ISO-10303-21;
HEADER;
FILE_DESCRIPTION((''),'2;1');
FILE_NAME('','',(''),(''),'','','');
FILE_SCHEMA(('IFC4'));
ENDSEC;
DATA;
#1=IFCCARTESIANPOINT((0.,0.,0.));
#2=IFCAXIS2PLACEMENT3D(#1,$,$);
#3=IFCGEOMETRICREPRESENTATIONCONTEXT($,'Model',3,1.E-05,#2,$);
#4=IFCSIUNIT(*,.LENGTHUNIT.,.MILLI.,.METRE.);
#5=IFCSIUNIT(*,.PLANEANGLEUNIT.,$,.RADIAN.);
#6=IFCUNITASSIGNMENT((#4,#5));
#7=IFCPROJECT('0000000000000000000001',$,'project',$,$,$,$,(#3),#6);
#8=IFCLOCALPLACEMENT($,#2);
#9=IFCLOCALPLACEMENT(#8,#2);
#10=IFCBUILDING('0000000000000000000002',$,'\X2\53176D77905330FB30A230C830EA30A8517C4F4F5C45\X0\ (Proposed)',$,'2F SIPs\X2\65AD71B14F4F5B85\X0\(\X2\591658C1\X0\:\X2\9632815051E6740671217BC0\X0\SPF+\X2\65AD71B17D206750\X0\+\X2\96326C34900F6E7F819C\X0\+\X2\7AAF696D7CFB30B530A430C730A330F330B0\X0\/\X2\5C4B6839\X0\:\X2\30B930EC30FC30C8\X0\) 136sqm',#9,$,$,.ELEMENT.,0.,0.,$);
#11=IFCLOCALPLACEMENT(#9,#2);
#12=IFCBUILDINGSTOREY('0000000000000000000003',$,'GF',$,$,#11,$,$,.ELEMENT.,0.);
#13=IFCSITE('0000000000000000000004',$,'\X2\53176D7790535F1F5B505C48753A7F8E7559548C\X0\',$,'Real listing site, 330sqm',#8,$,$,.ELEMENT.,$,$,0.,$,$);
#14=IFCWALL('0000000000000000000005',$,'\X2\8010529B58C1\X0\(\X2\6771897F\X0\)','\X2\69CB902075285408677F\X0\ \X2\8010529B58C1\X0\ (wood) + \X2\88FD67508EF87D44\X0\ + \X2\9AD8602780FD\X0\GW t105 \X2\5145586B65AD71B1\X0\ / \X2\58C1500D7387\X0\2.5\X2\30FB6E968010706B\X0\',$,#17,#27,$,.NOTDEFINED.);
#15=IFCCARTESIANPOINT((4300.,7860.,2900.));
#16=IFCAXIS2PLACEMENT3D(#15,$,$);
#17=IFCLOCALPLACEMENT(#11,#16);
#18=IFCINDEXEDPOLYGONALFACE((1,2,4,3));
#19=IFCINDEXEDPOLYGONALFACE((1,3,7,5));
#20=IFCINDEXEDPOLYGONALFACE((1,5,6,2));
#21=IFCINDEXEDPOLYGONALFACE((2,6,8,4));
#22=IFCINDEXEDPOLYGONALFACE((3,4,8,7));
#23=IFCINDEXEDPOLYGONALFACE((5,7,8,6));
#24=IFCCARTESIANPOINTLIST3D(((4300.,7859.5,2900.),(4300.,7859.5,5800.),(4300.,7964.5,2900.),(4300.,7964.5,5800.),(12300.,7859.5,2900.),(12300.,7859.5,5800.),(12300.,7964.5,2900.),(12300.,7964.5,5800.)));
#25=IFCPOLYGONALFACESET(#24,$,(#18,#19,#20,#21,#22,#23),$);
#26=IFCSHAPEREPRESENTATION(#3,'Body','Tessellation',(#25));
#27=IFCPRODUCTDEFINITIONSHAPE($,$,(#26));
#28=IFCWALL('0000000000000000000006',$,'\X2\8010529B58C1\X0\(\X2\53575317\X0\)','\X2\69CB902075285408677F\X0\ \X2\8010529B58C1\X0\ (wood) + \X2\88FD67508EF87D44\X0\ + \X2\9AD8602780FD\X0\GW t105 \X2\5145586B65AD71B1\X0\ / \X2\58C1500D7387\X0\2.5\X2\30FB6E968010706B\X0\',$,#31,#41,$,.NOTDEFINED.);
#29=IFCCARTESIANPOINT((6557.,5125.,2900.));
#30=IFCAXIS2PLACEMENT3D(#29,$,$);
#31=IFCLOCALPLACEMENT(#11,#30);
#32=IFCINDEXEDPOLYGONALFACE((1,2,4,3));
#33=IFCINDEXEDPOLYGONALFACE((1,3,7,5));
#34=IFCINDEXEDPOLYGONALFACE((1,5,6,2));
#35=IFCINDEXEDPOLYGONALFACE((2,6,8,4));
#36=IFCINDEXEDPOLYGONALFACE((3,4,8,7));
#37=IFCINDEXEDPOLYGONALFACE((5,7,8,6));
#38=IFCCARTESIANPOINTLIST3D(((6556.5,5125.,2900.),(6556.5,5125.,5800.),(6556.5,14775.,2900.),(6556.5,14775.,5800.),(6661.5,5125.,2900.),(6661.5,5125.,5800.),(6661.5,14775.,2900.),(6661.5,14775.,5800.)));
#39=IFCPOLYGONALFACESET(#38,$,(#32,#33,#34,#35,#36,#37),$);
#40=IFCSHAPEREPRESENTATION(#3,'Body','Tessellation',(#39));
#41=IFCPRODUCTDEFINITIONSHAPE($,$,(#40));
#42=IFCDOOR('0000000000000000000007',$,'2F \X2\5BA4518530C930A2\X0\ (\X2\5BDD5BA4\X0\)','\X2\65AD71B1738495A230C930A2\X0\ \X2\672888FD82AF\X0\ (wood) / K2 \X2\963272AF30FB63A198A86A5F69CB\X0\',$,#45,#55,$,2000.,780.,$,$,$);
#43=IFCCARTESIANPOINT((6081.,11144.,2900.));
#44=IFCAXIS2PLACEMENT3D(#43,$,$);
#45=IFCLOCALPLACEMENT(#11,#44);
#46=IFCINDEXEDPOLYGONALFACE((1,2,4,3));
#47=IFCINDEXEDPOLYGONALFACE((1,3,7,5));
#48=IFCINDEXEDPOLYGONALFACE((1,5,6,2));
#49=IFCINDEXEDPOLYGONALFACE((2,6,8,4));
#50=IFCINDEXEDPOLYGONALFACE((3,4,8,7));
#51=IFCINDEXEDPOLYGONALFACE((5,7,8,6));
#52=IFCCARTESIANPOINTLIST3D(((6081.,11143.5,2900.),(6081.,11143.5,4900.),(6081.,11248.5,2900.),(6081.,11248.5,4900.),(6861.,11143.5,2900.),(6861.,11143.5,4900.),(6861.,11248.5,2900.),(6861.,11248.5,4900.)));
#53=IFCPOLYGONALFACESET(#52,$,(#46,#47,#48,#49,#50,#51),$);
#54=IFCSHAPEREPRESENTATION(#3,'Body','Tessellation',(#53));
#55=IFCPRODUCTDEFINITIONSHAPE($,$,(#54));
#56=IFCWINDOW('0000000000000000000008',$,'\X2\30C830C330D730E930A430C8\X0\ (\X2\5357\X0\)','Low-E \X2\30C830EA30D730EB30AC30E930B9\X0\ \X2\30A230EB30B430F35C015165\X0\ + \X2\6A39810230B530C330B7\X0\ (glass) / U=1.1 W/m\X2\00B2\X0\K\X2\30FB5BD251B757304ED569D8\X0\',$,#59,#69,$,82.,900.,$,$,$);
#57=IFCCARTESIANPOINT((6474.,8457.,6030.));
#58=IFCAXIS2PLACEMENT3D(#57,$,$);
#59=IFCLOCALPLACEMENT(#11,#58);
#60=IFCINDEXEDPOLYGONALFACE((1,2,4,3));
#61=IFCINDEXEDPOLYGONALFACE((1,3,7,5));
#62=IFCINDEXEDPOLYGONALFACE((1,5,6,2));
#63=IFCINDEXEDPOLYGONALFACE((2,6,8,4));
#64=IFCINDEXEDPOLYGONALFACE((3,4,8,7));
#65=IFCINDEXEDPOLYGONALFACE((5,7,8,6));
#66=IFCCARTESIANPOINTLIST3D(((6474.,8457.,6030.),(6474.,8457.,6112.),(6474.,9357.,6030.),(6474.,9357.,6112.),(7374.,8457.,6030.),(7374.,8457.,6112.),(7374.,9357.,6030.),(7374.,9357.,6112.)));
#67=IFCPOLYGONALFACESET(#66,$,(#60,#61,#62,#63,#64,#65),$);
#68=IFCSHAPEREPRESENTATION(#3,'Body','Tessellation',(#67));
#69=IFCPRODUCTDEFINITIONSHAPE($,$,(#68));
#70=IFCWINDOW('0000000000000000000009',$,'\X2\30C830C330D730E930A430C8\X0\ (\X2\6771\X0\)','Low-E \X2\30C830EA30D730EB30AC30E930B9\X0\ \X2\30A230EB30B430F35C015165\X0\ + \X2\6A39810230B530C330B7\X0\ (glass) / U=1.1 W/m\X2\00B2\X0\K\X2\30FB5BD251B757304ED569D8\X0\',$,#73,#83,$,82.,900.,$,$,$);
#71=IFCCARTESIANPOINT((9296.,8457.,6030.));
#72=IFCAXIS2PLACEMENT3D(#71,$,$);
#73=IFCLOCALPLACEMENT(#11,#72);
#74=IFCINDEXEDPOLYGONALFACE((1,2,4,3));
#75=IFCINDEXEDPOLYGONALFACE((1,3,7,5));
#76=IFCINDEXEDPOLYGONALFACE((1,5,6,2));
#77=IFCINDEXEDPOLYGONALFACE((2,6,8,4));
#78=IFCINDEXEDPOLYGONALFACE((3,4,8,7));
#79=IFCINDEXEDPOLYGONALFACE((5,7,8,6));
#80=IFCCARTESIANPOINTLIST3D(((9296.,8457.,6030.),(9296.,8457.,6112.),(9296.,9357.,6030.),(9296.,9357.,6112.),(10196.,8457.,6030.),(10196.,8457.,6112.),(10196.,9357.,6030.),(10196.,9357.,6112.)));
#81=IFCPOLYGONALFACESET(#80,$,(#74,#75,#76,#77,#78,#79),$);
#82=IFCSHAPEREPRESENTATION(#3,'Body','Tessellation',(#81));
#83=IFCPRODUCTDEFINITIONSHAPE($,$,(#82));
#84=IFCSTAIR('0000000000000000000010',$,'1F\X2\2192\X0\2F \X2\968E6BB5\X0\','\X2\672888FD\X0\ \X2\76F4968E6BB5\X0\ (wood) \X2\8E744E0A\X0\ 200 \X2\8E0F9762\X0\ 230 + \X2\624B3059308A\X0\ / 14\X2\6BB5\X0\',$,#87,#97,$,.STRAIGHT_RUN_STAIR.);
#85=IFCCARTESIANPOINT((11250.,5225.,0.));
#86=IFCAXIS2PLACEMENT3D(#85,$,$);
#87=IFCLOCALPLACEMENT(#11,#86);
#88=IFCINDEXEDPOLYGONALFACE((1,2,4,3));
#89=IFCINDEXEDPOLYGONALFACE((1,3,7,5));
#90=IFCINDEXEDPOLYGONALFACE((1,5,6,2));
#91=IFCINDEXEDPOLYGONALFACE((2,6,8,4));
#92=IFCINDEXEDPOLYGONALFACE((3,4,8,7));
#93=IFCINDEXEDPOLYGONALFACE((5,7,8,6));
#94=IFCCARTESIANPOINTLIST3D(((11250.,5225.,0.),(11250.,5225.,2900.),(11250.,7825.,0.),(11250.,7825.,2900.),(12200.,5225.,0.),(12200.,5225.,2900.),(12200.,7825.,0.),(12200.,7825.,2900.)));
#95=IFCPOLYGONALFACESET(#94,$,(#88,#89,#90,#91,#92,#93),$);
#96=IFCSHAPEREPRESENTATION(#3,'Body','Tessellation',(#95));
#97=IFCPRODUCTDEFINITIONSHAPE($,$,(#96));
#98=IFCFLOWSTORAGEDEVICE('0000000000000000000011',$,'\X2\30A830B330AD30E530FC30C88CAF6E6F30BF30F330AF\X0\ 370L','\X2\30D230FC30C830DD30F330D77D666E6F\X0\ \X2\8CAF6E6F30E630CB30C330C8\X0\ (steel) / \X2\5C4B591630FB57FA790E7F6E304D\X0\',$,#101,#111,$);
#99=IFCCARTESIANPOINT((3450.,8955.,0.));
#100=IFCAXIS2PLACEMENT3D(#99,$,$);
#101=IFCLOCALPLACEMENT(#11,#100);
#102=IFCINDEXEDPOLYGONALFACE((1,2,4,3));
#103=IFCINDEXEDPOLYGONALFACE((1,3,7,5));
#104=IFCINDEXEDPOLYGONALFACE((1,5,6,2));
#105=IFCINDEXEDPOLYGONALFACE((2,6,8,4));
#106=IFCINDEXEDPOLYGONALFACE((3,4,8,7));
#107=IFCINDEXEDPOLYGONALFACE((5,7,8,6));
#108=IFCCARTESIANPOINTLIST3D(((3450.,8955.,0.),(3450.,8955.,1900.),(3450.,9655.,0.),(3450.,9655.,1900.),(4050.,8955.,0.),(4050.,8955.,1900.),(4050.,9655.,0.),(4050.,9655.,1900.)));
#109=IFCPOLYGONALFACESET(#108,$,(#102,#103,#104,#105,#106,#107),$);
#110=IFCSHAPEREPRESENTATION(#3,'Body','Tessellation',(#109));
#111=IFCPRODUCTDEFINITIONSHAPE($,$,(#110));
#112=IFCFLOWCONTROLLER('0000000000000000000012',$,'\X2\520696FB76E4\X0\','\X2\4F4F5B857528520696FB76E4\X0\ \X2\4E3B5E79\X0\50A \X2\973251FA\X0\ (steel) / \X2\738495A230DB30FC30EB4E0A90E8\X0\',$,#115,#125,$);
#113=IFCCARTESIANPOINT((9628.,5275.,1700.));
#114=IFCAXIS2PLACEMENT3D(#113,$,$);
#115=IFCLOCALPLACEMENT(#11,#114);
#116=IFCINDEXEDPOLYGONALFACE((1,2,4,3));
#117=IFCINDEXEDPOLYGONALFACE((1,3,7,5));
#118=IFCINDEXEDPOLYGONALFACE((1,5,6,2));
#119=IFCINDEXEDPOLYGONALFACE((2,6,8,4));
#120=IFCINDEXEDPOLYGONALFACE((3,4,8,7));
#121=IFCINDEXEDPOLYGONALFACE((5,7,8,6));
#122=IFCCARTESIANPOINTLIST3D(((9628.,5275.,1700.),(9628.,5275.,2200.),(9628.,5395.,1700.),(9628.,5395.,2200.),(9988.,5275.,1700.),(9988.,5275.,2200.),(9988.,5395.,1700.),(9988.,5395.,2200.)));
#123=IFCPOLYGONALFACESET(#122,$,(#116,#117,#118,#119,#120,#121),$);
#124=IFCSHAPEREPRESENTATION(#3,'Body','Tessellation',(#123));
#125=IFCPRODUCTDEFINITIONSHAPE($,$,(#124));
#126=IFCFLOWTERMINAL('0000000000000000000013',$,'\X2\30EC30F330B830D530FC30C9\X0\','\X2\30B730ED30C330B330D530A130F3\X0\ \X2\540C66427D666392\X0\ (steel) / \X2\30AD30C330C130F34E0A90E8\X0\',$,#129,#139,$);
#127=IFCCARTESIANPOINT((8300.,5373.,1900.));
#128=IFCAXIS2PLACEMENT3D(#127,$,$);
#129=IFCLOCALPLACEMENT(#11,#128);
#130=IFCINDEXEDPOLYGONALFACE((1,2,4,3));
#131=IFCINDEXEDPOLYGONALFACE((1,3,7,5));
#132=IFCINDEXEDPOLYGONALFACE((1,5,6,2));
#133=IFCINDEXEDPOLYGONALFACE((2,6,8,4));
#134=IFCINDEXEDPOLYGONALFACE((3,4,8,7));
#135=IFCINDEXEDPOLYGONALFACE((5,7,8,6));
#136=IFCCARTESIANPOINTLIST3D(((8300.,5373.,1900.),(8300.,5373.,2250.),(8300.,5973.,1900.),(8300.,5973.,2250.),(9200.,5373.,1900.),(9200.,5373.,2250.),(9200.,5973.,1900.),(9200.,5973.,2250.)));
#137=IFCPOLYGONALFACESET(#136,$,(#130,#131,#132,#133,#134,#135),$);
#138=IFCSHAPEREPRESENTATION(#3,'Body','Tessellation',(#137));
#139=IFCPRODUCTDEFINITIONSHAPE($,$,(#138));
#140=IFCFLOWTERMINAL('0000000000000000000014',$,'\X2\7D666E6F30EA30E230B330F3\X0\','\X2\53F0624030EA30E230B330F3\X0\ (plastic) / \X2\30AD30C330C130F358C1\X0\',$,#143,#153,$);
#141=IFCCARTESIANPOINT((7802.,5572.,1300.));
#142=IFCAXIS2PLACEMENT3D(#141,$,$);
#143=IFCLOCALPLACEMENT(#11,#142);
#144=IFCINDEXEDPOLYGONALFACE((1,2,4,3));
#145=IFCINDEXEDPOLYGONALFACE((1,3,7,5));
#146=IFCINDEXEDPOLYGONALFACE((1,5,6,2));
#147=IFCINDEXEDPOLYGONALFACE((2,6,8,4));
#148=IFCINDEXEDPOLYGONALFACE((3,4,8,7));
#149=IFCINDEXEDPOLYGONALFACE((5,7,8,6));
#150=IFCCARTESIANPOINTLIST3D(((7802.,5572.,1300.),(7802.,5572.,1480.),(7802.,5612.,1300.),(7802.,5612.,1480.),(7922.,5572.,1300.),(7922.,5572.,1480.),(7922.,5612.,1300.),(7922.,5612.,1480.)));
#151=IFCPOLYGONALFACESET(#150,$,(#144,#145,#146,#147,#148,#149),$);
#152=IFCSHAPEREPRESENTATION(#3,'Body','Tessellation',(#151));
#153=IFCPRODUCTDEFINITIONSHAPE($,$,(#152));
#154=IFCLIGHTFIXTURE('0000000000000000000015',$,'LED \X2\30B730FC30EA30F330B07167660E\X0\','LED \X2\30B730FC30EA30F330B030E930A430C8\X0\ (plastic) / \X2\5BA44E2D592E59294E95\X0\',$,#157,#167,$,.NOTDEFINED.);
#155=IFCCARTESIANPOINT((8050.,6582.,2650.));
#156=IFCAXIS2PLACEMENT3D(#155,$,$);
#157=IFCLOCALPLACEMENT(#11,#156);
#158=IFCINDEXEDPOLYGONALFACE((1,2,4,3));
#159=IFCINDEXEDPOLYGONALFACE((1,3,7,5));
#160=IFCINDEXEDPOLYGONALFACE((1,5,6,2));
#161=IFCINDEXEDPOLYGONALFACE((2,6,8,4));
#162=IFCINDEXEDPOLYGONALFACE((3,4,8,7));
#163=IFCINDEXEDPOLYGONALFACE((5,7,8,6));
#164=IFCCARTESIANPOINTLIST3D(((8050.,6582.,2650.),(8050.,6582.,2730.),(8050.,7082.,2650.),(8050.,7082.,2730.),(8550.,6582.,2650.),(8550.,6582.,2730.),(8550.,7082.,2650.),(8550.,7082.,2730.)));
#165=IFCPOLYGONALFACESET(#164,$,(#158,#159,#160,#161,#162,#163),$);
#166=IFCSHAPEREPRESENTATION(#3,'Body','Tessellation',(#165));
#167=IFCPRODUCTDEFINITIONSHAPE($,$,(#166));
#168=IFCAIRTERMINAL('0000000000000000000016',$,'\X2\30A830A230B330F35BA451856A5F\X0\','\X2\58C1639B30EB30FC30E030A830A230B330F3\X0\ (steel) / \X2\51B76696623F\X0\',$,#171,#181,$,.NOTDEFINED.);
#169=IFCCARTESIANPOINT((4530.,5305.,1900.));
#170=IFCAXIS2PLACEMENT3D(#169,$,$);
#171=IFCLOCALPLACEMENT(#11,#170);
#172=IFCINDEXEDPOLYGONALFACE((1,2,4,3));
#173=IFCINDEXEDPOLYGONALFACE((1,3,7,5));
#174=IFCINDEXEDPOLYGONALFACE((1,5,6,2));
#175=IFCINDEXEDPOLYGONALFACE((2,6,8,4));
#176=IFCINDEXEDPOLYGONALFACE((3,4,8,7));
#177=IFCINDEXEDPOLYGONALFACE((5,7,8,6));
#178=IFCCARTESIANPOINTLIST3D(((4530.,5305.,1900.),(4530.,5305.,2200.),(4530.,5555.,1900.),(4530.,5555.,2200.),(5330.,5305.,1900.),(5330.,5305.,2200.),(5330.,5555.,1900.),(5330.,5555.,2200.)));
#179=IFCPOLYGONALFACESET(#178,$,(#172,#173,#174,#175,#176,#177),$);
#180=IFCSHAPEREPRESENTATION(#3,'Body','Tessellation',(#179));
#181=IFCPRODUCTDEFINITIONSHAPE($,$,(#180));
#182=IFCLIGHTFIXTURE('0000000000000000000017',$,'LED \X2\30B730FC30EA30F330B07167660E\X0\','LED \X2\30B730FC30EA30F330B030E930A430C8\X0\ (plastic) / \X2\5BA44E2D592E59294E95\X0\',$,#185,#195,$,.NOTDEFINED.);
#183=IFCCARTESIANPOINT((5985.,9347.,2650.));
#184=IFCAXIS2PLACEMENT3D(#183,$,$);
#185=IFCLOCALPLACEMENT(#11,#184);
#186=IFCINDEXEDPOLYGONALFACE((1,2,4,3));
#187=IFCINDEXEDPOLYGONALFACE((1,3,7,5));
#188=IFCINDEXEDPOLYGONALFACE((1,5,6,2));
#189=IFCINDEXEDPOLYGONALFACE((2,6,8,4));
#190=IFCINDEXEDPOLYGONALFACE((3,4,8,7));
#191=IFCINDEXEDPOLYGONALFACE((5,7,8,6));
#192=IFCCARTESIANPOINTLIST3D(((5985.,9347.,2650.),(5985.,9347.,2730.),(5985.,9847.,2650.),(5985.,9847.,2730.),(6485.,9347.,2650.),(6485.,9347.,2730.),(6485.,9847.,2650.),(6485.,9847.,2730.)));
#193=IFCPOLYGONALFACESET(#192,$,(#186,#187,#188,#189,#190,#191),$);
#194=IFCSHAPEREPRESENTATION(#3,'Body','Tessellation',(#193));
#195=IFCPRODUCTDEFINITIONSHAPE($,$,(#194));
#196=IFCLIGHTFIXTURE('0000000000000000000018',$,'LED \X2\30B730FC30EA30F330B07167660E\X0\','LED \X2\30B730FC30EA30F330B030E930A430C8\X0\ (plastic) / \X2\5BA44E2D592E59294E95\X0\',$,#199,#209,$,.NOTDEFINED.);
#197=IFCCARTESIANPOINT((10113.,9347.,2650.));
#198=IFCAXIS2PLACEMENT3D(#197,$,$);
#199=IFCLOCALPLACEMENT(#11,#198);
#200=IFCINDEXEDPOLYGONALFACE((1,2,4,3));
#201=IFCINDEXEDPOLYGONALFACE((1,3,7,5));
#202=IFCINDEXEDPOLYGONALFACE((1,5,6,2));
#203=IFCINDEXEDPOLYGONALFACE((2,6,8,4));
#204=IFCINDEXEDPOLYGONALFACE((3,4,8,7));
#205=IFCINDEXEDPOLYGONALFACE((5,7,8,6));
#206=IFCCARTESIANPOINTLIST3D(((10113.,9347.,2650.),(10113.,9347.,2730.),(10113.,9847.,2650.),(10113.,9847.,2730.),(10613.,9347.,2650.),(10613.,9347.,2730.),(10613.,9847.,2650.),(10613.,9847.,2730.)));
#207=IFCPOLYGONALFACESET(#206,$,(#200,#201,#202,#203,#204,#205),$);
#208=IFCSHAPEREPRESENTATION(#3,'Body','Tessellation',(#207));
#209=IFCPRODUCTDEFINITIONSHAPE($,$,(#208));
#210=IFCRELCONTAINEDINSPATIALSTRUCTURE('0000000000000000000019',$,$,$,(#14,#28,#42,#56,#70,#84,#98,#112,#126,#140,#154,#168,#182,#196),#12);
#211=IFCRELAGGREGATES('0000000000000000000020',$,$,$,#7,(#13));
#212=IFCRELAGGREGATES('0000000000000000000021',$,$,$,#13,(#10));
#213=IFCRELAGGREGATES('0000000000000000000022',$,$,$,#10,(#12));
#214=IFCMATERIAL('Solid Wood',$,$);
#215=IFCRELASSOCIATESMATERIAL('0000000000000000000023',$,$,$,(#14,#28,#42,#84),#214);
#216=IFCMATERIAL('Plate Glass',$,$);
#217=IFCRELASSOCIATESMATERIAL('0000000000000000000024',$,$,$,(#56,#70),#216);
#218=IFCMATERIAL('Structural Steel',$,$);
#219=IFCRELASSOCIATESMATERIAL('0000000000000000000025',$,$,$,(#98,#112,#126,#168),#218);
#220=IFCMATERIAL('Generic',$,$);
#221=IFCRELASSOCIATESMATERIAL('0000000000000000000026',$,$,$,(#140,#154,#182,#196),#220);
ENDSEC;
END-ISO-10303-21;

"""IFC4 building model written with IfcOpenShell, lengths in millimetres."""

from ifc_helpers import new_model, si_unit, frame, frame_2d, origin, place, context, project, spatial, rectangle, extrude, material, element, fill, save


model = new_model("IFC4")

# Units and contexts
model_context = context("Model", 3, precision=1e-05, world=origin())
ifc_project = project(units=[si_unit("LENGTHUNIT", "METRE", prefix="MILLI"), si_unit("PLANEANGLEUNIT", "RADIAN")], contexts=[model_context])

# Site, building, storey
site_placement = place(None, origin())
site = spatial("IfcSite", under=ifc_project, at=site_placement, Name="北海道弟子屈町美留和", ObjectType="Real listing site, 330sqm", CompositionType="ELEMENT", RefElevation=0.0)
building_placement = place(site_placement, origin())
building = spatial("IfcBuilding", under=site, at=building_placement, Name="北海道・アトリエ兼住居 (Proposed)", ObjectType="2F SIPs断熱住宅(外壁:防腐処理無節SPF+断熱素材+防水透湿膜+窯業系サイディング/屋根:スレート) 136sqm", CompositionType="ELEMENT", ElevationOfRefHeight=0.0, ElevationOfTerrain=0.0)
storey_placement = place(building_placement, origin())
storey = spatial("IfcBuildingStorey", under=building, at=storey_placement, Name="GF", CompositionType="ELEMENT", Elevation=0.0)

# Shared definitions
ifc_material_1 = material(Name="Solid Wood")

# Wall
wall_1_placement = place(storey_placement, frame((4300.0, 7860.0, 2900.0)))
element("IfcWall", 1, at=wall_1_placement, inside=storey, material=ifc_material_1, Name="耐力壁(東西)", Description="構造用合板 耐力壁 (wood) + 製材軸組 + 高性能GW t105 充填断熱 / 壁倍率2.5・準耐火", PredefinedType="NOTDEFINED", context=model_context, shape_type="SweptSolid", body=[
    extrude(rectangle(XDim=8000.0, YDim=105.0, at=frame_2d((4000.0, 52.0))), frame((4300.0, 7860.0, 2900.0)), (0.0, 0.0, 1.0), 2900.0),
])

# Wall, opening, door
wall_2_placement = place(storey_placement, frame((6557.0, 5125.0, 2900.0)))
wall_2 = element("IfcWall", 2, at=wall_2_placement, inside=storey, material=ifc_material_1, Name="耐力壁(南北)", Description="構造用合板 耐力壁 (wood) + 製材軸組 + 高性能GW t105 充填断熱 / 壁倍率2.5・準耐火", PredefinedType="NOTDEFINED", context=model_context, shape_type="SweptSolid", body=[
    extrude(rectangle(XDim=105.0, YDim=9650.0, at=frame_2d((52.0, 4825.0))), frame((6557.0, 5125.0, 2900.0)), (0.0, 0.0, 1.0), 2900.0),
])
opening_placement = place(storey_placement, frame((6081.0, 11144.0, 2900.0)))
opening = element("IfcOpeningElement", 3, at=opening_placement, cuts=wall_2, PredefinedType="NOTDEFINED", context=model_context, shape_type="SweptSolid", body=[
    extrude(rectangle(XDim=780.0, YDim=105.0, at=frame_2d((390.0, 52.0))), frame((6081.0, 11144.0, 2900.0)), (0.0, 0.0, 1.0), 2000.0),
])
door_placement = place(storey_placement, frame((6081.0, 11144.0, 2900.0)))
door = element("IfcDoor", 4, at=door_placement, inside=storey, material=ifc_material_1, Name="2F 室内ドア (寝室)", Description="断熱玄関ドア 木製芯 (wood) / K2 防犯・採風機構", OverallHeight=2000.0, OverallWidth=780.0, context=model_context, shape_type="SweptSolid", body=[
    extrude(rectangle(XDim=780.0, YDim=105.0, at=frame_2d((390.0, 52.0))), frame((6081.0, 11144.0, 2900.0)), (0.0, 0.0, 1.0), 2000.0),
])
fill(opening, door)

# Windows
ifc_material_2 = material(Name="Plate Glass")
window_1_placement = place(storey_placement, frame((6474.0, 8457.0, 6030.0)))
element("IfcWindow", 5, at=window_1_placement, inside=storey, material=ifc_material_2, Name="トップライト (南)", Description="Low-E トリプルガラス アルゴン封入 + 樹脂サッシ (glass) / U=1.1 W/m²K・寒冷地仕様", OverallHeight=82.0, OverallWidth=900.0, context=model_context, shape_type="SweptSolid", body=[
    extrude(rectangle(XDim=900.0, YDim=900.0, at=frame_2d((450.0, 450.0))), frame((6474.0, 8457.0, 6030.0)), (0.0, 0.0, 1.0), 82.0),
])
window_2_placement = place(storey_placement, frame((9296.0, 8457.0, 6030.0)))
element("IfcWindow", 6, at=window_2_placement, inside=storey, material=ifc_material_2, Name="トップライト (東)", Description="Low-E トリプルガラス アルゴン封入 + 樹脂サッシ (glass) / U=1.1 W/m²K・寒冷地仕様", OverallHeight=82.0, OverallWidth=900.0, context=model_context, shape_type="SweptSolid", body=[
    extrude(rectangle(XDim=900.0, YDim=900.0, at=frame_2d((450.0, 450.0))), frame((9296.0, 8457.0, 6030.0)), (0.0, 0.0, 1.0), 82.0),
])

# Stair
stair_placement = place(storey_placement, frame((11250.0, 5225.0, 0.0)))
element("IfcStair", 7, at=stair_placement, inside=storey, material=ifc_material_1, Name="1F→2F 階段", Description="木製 直階段 (wood) 蹴上 200 踏面 230 + 手すり / 14段", PredefinedType="STRAIGHT_RUN_STAIR", context=model_context, shape_type="SweptSolid", body=[
    extrude(rectangle(XDim=950.0, YDim=2600.0, at=frame_2d((475.0, 1300.0))), frame((11250.0, 5225.0, 0.0)), (0.0, 0.0, 1.0), 2900.0),
])

# Flow storage device
ifc_material_3 = material(Name="Structural Steel")
flow_storage_device_placement = place(storey_placement, frame((3450.0, 8955.0, 0.0)))
element("IfcFlowStorageDevice", 8, at=flow_storage_device_placement, inside=storey, material=ifc_material_3, Name="エコキュート貯湯タンク 370L", Description="ヒートポンプ給湯 貯湯ユニット (steel) / 屋外・基礎置き", context=model_context, shape_type="SweptSolid", body=[
    extrude(rectangle(XDim=600.0, YDim=700.0, at=frame_2d((300.0, 350.0))), frame((3450.0, 8955.0, 0.0)), (0.0, 0.0, 1.0), 1900.0),
])

# Flow controller
flow_controller_placement = place(storey_placement, frame((9628.0, 5275.0, 1700.0)))
element("IfcFlowController", 9, at=flow_controller_placement, inside=storey, material=ifc_material_3, Name="分電盤", Description="住宅用分電盤 主幹50A 露出 (steel) / 玄関ホール上部", context=model_context, shape_type="SweptSolid", body=[
    extrude(rectangle(XDim=360.0, YDim=120.0, at=frame_2d((180.0, 60.0))), frame((9628.0, 5275.0, 1700.0)), (0.0, 0.0, 1.0), 500.0),
])

# Flow terminals
flow_terminal_1_placement = place(storey_placement, frame((8300.0, 5373.0, 1900.0)))
element("IfcFlowTerminal", 10, at=flow_terminal_1_placement, inside=storey, material=ifc_material_3, Name="レンジフード", Description="シロッコファン 同時給排 (steel) / キッチン上部", context=model_context, shape_type="SweptSolid", body=[
    extrude(rectangle(XDim=900.0, YDim=600.0, at=frame_2d((450.0, 300.0))), frame((8300.0, 5373.0, 1900.0)), (0.0, 0.0, 1.0), 350.0),
])
ifc_material_4 = material(Name="Generic")
flow_terminal_2_placement = place(storey_placement, frame((7802.0, 5572.0, 1300.0)))
element("IfcFlowTerminal", 11, at=flow_terminal_2_placement, inside=storey, material=ifc_material_4, Name="給湯リモコン", Description="台所リモコン (plastic) / キッチン壁", context=model_context, shape_type="SweptSolid", body=[
    extrude(rectangle(XDim=120.0, YDim=40.0, at=frame_2d((60.0, 20.0))), frame((7802.0, 5572.0, 1300.0)), (0.0, 0.0, 1.0), 180.0),
])

# Light fixture
light_fixture_1_placement = place(storey_placement, frame((8050.0, 6582.0, 2650.0)))
element("IfcLightFixture", 12, at=light_fixture_1_placement, inside=storey, material=ifc_material_4, Name="LED シーリング照明", Description="LED シーリングライト (plastic) / 室中央天井", PredefinedType="NOTDEFINED", context=model_context, shape_type="SweptSolid", body=[
    extrude(rectangle(XDim=500.0, YDim=500.0, at=frame_2d((250.0, 250.0))), frame((8050.0, 6582.0, 2650.0)), (0.0, 0.0, 1.0), 80.0),
])

# Air terminal
air_terminal_1_placement = place(storey_placement, frame((4530.0, 5305.0, 1900.0)))
element("IfcAirTerminal", 13, at=air_terminal_1_placement, inside=storey, material=ifc_material_3, Name="エアコン室内機", Description="壁掛ルームエアコン (steel) / 冷暖房", PredefinedType="NOTDEFINED", context=model_context, shape_type="SweptSolid", body=[
    extrude(rectangle(XDim=800.0, YDim=250.0, at=frame_2d((400.0, 125.0))), frame((4530.0, 5305.0, 1900.0)), (0.0, 0.0, 1.0), 300.0),
])

# Light fixtures
light_fixture_2_placement = place(storey_placement, frame((5985.0, 9347.0, 2650.0)))
element("IfcLightFixture", 14, at=light_fixture_2_placement, inside=storey, material=ifc_material_4, Name="LED シーリング照明", Description="LED シーリングライト (plastic) / 室中央天井", PredefinedType="NOTDEFINED", context=model_context, shape_type="SweptSolid", body=[
    extrude(rectangle(XDim=500.0, YDim=500.0, at=frame_2d((250.0, 250.0))), frame((5985.0, 9347.0, 2650.0)), (0.0, 0.0, 1.0), 80.0),
])
light_fixture_3_placement = place(storey_placement, frame((10113.0, 9347.0, 2650.0)))
element("IfcLightFixture", 15, at=light_fixture_3_placement, inside=storey, material=ifc_material_4, Name="LED シーリング照明", Description="LED シーリングライト (plastic) / 室中央天井", PredefinedType="NOTDEFINED", context=model_context, shape_type="SweptSolid", body=[
    extrude(rectangle(XDim=500.0, YDim=500.0, at=frame_2d((250.0, 250.0))), frame((10113.0, 9347.0, 2650.0)), (0.0, 0.0, 1.0), 80.0),
])

save(model, "model.ifc")
